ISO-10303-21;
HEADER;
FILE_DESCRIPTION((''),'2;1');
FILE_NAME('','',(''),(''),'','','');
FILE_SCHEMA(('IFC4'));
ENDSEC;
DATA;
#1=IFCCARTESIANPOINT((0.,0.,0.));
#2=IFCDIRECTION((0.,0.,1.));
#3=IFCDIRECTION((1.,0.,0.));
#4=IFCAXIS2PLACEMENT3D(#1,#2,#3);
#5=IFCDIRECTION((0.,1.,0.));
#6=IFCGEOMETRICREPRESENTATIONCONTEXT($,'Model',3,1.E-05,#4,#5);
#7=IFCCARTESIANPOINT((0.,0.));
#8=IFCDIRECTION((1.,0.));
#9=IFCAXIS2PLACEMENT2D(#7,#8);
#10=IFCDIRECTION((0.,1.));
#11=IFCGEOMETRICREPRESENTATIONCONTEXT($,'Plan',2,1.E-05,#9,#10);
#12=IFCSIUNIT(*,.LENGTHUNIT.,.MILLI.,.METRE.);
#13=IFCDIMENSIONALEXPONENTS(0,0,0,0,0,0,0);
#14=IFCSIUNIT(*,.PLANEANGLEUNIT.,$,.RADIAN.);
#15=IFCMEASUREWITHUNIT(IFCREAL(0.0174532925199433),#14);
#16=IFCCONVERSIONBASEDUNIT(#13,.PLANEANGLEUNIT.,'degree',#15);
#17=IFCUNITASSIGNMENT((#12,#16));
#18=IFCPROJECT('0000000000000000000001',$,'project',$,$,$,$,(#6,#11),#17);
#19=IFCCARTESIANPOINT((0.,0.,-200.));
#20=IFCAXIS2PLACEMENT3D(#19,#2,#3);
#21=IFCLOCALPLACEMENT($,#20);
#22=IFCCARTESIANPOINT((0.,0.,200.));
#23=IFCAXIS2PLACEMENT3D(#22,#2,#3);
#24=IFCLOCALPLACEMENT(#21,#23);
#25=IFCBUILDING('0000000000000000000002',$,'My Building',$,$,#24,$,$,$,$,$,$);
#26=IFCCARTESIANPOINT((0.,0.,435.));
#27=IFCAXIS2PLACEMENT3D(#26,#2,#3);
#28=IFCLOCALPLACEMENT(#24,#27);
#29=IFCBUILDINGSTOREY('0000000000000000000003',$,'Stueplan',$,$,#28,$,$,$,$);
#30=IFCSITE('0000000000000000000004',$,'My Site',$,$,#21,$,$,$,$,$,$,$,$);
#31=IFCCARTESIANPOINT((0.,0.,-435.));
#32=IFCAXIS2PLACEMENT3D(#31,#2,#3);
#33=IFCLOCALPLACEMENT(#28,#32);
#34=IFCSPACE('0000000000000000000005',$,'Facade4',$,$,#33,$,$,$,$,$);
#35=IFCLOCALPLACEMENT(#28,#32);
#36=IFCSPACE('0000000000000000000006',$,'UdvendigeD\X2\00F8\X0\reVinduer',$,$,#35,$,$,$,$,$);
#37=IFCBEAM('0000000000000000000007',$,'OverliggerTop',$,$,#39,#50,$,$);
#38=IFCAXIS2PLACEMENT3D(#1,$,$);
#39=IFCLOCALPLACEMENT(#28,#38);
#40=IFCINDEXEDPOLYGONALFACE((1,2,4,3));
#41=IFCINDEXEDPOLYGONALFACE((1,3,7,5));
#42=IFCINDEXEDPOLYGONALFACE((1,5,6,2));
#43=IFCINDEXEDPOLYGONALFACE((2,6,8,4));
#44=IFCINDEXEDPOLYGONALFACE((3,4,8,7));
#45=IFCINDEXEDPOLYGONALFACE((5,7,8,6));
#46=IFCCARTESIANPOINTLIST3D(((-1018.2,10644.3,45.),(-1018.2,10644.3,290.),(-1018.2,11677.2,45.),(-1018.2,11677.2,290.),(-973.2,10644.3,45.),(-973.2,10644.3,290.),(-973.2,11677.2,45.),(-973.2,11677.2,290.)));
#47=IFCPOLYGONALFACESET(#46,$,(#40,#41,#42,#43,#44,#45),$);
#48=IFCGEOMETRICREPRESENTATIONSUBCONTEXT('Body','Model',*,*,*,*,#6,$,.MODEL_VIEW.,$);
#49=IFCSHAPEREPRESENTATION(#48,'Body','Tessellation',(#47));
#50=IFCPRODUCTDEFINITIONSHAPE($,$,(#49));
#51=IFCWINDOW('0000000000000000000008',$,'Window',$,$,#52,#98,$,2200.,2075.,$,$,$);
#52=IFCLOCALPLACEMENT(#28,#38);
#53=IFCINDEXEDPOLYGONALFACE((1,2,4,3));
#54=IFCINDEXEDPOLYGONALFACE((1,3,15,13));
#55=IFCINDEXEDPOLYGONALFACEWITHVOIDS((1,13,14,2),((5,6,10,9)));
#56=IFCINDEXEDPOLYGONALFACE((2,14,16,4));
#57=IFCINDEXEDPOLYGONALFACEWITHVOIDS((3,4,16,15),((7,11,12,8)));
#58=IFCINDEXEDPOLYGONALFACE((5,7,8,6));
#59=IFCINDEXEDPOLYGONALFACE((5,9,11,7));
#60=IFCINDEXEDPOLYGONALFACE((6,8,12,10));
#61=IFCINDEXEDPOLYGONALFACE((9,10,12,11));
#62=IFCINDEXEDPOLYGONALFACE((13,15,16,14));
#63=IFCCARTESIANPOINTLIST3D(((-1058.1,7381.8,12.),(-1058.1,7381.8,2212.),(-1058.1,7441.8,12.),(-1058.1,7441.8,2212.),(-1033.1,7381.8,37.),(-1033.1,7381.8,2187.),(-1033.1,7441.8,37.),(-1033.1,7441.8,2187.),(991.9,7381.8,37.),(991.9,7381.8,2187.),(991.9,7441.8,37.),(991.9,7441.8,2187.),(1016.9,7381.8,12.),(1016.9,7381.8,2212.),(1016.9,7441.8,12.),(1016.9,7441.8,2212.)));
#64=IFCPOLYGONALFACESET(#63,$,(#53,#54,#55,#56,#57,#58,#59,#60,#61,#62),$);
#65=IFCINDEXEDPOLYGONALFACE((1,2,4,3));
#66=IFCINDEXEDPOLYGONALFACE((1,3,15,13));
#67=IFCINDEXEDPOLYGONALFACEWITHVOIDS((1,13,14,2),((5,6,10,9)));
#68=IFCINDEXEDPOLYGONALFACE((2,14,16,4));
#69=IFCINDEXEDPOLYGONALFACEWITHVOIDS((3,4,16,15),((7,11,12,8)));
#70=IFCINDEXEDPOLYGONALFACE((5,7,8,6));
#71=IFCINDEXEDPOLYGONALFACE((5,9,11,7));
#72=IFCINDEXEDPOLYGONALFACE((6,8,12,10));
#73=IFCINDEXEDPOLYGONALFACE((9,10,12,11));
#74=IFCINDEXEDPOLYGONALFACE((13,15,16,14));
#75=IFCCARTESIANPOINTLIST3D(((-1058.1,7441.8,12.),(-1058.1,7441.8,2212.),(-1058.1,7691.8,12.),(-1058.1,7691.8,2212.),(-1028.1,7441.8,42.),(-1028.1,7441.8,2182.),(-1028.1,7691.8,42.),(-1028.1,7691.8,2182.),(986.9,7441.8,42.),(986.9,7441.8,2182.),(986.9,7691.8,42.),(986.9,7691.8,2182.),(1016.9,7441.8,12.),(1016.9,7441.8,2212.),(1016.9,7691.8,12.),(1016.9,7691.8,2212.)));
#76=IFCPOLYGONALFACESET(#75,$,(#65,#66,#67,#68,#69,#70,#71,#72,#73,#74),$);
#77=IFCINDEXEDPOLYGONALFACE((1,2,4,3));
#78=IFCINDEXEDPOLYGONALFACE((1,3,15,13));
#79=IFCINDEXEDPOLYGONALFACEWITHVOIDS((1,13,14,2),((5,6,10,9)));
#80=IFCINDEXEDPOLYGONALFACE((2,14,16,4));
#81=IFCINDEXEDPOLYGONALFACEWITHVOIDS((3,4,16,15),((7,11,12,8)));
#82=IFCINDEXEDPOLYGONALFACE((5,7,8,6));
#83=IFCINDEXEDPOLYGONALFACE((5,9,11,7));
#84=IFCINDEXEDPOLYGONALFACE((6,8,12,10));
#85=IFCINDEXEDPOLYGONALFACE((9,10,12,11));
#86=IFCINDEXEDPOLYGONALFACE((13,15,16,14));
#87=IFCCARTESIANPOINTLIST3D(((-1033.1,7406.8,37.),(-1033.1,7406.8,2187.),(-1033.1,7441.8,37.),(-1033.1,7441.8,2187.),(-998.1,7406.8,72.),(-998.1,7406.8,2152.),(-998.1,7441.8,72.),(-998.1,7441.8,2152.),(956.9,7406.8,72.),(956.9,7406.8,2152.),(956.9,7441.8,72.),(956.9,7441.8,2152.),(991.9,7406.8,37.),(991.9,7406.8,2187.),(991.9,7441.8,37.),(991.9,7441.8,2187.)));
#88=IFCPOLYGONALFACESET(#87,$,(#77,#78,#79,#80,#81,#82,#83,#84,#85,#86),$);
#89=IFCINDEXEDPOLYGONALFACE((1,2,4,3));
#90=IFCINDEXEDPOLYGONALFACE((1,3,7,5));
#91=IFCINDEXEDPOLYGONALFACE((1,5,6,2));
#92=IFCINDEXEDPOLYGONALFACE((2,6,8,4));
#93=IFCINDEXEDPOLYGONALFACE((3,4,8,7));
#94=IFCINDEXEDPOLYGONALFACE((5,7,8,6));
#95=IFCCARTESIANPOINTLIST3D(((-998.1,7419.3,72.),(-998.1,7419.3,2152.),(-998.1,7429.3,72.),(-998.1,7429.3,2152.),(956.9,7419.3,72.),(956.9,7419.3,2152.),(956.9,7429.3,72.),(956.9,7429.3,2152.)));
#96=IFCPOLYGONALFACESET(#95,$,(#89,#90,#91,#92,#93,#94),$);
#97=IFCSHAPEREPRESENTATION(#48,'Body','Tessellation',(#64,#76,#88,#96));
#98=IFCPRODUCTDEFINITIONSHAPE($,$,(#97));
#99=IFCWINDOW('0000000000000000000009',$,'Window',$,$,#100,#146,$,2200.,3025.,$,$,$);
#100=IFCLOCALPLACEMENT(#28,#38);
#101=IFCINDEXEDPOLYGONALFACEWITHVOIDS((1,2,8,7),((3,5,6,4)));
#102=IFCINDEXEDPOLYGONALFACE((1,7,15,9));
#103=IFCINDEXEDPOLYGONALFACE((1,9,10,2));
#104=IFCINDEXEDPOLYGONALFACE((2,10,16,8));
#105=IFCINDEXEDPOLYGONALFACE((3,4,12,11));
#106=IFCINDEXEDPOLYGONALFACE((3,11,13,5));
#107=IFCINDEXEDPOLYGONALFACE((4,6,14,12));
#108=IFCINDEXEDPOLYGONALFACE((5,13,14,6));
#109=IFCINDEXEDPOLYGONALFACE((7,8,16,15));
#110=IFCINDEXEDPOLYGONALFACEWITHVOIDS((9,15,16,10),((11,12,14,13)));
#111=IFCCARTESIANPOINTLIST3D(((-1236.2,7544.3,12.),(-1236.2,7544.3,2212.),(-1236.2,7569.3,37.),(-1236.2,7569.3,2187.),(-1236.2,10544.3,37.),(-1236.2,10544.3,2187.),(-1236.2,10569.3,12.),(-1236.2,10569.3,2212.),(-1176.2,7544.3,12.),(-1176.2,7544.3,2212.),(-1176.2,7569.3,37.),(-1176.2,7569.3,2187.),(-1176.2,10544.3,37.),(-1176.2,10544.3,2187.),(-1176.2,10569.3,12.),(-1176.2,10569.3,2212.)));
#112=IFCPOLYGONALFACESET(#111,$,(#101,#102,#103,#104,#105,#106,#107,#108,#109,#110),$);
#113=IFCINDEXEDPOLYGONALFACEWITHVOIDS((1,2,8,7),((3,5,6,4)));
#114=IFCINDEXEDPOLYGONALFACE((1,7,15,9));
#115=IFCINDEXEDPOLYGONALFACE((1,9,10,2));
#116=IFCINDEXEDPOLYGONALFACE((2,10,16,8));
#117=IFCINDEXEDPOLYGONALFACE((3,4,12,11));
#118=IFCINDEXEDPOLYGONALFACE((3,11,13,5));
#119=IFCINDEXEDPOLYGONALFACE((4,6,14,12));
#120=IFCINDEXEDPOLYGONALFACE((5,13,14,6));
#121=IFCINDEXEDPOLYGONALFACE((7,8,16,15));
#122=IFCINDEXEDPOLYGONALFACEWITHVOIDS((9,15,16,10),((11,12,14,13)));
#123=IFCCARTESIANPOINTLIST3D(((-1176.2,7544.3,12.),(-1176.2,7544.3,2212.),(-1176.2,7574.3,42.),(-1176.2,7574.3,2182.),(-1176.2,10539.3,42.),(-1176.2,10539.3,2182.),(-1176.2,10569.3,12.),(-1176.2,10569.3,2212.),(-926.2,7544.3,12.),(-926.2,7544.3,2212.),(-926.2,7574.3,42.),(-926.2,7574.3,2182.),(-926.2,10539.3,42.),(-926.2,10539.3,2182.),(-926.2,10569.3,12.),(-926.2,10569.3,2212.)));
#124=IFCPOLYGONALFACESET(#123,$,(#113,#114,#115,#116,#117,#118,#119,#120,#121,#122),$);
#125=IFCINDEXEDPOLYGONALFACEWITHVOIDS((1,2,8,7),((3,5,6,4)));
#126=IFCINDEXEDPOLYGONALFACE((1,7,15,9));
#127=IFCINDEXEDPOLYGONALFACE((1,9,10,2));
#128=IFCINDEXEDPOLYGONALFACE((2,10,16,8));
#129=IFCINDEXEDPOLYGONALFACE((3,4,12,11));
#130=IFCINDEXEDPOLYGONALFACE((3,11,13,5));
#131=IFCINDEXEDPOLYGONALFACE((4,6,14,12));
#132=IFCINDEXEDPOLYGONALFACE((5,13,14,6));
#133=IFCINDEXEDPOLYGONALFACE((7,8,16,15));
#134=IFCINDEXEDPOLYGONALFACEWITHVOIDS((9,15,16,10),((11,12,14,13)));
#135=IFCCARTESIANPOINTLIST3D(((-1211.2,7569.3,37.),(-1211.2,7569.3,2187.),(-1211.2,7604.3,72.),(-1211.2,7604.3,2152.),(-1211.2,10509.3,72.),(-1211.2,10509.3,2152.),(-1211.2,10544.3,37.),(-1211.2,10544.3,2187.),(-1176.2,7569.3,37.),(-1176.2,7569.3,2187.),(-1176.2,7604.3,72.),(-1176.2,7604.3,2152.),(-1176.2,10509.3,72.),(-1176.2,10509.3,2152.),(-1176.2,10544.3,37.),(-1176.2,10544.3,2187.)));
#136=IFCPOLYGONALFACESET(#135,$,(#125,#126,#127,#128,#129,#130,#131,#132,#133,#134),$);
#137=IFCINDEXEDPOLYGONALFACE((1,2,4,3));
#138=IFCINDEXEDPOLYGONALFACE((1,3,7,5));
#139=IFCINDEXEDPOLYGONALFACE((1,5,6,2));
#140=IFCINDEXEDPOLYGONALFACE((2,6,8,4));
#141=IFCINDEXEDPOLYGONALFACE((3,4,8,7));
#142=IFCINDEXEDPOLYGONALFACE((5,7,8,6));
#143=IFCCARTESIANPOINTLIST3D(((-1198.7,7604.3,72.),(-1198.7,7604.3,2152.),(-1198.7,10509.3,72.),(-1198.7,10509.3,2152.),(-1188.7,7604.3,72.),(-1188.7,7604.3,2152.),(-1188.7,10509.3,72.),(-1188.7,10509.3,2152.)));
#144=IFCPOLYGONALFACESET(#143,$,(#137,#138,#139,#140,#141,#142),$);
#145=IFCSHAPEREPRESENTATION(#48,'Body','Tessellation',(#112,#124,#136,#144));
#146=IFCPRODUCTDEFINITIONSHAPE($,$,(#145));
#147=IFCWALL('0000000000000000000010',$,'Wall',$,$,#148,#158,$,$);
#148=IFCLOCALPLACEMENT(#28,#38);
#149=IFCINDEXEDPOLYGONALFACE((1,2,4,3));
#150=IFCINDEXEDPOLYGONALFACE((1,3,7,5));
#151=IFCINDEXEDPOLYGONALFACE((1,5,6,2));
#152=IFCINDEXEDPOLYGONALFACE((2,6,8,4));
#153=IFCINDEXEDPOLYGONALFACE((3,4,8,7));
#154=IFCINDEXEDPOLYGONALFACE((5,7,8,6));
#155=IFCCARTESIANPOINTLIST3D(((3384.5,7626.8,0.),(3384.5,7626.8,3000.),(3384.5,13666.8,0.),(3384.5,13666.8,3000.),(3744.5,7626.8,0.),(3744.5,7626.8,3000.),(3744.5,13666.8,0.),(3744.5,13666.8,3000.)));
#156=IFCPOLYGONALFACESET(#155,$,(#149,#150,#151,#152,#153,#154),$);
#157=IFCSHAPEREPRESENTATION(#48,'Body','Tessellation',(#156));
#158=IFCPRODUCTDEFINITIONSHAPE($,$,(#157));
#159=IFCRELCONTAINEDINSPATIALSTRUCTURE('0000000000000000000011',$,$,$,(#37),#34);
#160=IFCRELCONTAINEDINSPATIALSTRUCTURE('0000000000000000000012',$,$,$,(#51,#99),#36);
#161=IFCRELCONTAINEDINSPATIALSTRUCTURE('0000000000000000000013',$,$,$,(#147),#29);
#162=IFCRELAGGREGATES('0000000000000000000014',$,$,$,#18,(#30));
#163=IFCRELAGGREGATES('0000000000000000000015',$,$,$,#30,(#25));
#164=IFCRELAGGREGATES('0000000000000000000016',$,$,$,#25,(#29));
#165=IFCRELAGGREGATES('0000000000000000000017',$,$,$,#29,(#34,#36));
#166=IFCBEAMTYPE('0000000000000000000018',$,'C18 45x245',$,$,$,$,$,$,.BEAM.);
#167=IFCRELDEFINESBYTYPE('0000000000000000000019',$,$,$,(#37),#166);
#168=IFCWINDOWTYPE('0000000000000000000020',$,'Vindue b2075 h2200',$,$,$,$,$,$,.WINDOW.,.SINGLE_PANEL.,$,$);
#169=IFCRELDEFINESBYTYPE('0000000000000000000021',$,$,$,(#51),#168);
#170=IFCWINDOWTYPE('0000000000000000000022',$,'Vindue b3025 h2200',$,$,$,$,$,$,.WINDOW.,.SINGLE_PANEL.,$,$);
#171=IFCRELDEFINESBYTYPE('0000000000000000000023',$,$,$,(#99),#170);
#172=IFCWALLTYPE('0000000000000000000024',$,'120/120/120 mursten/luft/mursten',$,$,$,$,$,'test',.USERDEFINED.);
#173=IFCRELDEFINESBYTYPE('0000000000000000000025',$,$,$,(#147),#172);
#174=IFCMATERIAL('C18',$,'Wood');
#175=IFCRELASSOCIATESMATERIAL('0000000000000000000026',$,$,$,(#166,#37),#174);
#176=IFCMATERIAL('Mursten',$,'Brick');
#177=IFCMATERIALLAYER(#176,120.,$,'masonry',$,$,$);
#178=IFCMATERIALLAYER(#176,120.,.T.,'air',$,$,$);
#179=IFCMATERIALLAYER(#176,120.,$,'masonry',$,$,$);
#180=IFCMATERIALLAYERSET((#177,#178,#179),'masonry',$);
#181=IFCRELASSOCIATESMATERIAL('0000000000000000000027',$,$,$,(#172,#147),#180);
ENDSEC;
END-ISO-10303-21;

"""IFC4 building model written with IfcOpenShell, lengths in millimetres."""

from ifc_helpers import new_model, entity, si_unit, converted_unit, direction, frame, origin_with_axes, origin_2d_with_axis, place, context, subcontext, project, spatial, line, indexed_curve, rectangle, outline, extrude, shape, source, transform, mapped, material, layer, layer_set, layer_usage, material_profile, profile_set, profile_usage, type_object, type_shapes, element, save


model = new_model("IFC4")

# Units and contexts
model_context = context("Model", 3, precision=1e-05, world=origin_with_axes(), true_north=direction((0.0, 1.0, 0.0)))
plan_context = context("Plan", 2, precision=1e-05, world=origin_2d_with_axis(), true_north=direction((0.0, 1.0)))
body_context_1 = subcontext(model_context, "Body", "Model", "MODEL_VIEW")
body_context_2 = subcontext(plan_context, "Body", "Plan", "PLAN_VIEW")
ifc_project = project(units=[si_unit("LENGTHUNIT", "METRE", prefix="MILLI"), converted_unit("PLANEANGLEUNIT", "degree", entity("IfcReal", 0.0174532925199433), si_unit("PLANEANGLEUNIT", "RADIAN"), dimensions=[0, 0, 0, 0, 0, 0, 0])], contexts=[model_context, plan_context])

# Site, building, storey
site_placement = place(None, frame((0.0, 0.0, -200.0), z_axis=(0.0, 0.0, 1.0), x_axis=(1.0, 0.0, 0.0)))
site = spatial("IfcSite", under=ifc_project, at=site_placement, Name="My Site")
building_placement = place(site_placement, frame((0.0, 0.0, 200.0), z_axis=(0.0, 0.0, 1.0), x_axis=(1.0, 0.0, 0.0)))
building = spatial("IfcBuilding", under=site, at=building_placement, Name="My Building")
storey_placement = place(building_placement, frame((0.0, 0.0, 435.0), z_axis=(0.0, 0.0, 1.0), x_axis=(1.0, 0.0, 0.0)))
storey = spatial("IfcBuildingStorey", under=building, at=storey_placement, Name="Stueplan")

# Shared definitions
ifc_material_1 = material(Name="C18", Category="Wood")

# Shared definitions
space_1_placement = place(storey_placement, frame((0.0, 0.0, -435.0), z_axis=(0.0, 0.0, 1.0), x_axis=(1.0, 0.0, 0.0)))
space_1 = spatial("IfcSpace", under=storey, at=space_1_placement, Name="Facade4")

# Beam
ifc_material_profile_1 = material_profile(ifc_material_1, rectangle(XDim=45.0, YDim=245.0), Name="concrete")
ifc_profile_set_1 = profile_set([ifc_material_profile_1], Name="woodStructural")
beam_type = type_object("IfcBeamType", Name="C18 45x245", PredefinedType="BEAM", material=ifc_profile_set_1)
ifc_profile_usage_1 = profile_usage(ifc_profile_set_1)
beam_1_placement = place(space_1_placement, frame((-995.7, 11677.2, 602.5), z_axis=(0.0, -1.0, 0.0), x_axis=(-1.0, 0.0, 0.0)))
element("IfcBeam", 1, at=beam_1_placement, inside=space_1, type_object=beam_type, material=ifc_profile_usage_1, Name="OverliggerTop", context=body_context_1, shape_type="SweptSolid", body=[
    extrude(rectangle(XDim=45.0, YDim=245.0), origin_with_axes(), (0.0, 0.0, 1.0), 1032.9),
])

# Shared definitions
space_2_placement = place(storey_placement, frame((0.0, 0.0, -435.0), z_axis=(0.0, 0.0, 1.0), x_axis=(1.0, 0.0, 0.0)))
space_2 = spatial("IfcSpace", under=storey, at=space_2_placement, Name="UdvendigeDøreVinduer")

# Windows
window_type_1 = type_object("IfcWindowType", Name="Vindue b2075 h2200", PartitioningType="SINGLE_PANEL", PredefinedType="WINDOW")
shared_shape_1 = source(origin_with_axes(), body_context_1, "Body", "SweptSolid", [
    extrude(outline(indexed_curve([(0.0, 0.0), (2075.0, 0.0), (2075.0, 2200.0), (0.0, 2200.0)], segments=[line(1, 2, 3, 4, 1)]), holes=[indexed_curve([(25.0, 25.0), (2050.0, 25.0), (2050.0, 2175.0), (25.0, 2175.0)], segments=[line(1, 2, 3, 4, 1)])]), frame((0.0, 250.0, 0.0), z_axis=(0.0, -1.0, 0.0), x_axis=(1.0, 0.0, 0.0)), (0.0, 0.0, -1.0), 60.0),
    extrude(outline(indexed_curve([(0.0, 0.0), (2075.0, 0.0), (2075.0, 2200.0), (0.0, 2200.0)], segments=[line(1, 2, 3, 4, 1)]), holes=[indexed_curve([(30.0, 30.0), (2045.0, 30.0), (2045.0, 2170.0), (30.0, 2170.0)], segments=[line(1, 2, 3, 4, 1)])]), frame((0.0, 0.0, 0.0), z_axis=(0.0, -1.0, 0.0), x_axis=(1.0, 0.0, 0.0)), (0.0, 0.0, -1.0), 250.0),
    extrude(outline(indexed_curve([(0.0, 0.0), (2025.0, 0.0), (2025.0, 2150.0), (0.0, 2150.0)], segments=[line(1, 2, 3, 4, 1)]), holes=[indexed_curve([(35.0, 35.0), (1990.0, 35.0), (1990.0, 2115.0), (35.0, 2115.0)], segments=[line(1, 2, 3, 4, 1)])]), frame((25.0, 250.0, 25.0), z_axis=(0.0, -1.0, 0.0), x_axis=(1.0, 0.0, 0.0)), (0.0, 0.0, -1.0), 35.0),
    extrude(outline(indexed_curve([(35.0, 35.0), (1990.0, 35.0), (1990.0, 2115.0), (35.0, 2115.0)], segments=[line(1, 2, 3, 4, 1)])), frame((25.0, 262.5, 25.0), z_axis=(0.0, -1.0, 0.0), x_axis=(1.0, 0.0, 0.0)), (0.0, 0.0, -1.0), 10.0),
])
shared_shape_2 = source(origin_with_axes(), body_context_2, "Body", "Curve2D", [
    entity("IfcIndexedPolyCurve", entity("IfcCartesianPointList2D", [[30.0, 0.0], [2045.0, 0.0]])),
    entity("IfcIndexedPolyCurve", entity("IfcCartesianPointList2D", [[0.0, 310.0], [25.0, 310.0], [25.0, 250.0], [30.0, 250.0], [30.0, 0.0], [0.0, 0.0]]), [entity("IfcLineIndex", [1, 2, 3, 4, 5, 6, 1])]),
    entity("IfcIndexedPolyCurve", entity("IfcCartesianPointList2D", [[2075.0, 310.0], [2050.0, 310.0], [2050.0, 250.0], [2045.0, 250.0], [2045.0, 0.0], [2075.0, 0.0]]), [entity("IfcLineIndex", [1, 2, 3, 4, 5, 6, 1])]),
    entity("IfcIndexedPolyCurve", entity("IfcCartesianPointList2D", [[25.0, 250.0], [60.0, 250.0], [60.0, 285.0], [25.0, 285.0]]), [entity("IfcLineIndex", [1, 2, 3, 4, 1])]),
    entity("IfcIndexedPolyCurve", entity("IfcCartesianPointList2D", [[2050.0, 250.0], [2015.0, 250.0], [2015.0, 285.0], [2050.0, 285.0]]), [entity("IfcLineIndex", [1, 2, 3, 4, 1])]),
    entity("IfcIndexedPolyCurve", entity("IfcCartesianPointList2D", [[60.0, 250.0], [2015.0, 250.0]])),
    entity("IfcIndexedPolyCurve", entity("IfcCartesianPointList2D", [[60.0, 285.0], [2015.0, 285.0]])),
    entity("IfcIndexedPolyCurve", entity("IfcCartesianPointList2D", [[60.0, 267.5], [2015.0, 267.5]])),
])
type_shapes(window_type_1, [shared_shape_1, shared_shape_2])
placement_1 = place(storey_placement, frame((0.0, 0.0, -435.0), z_axis=(0.0, 0.0, 1.0), x_axis=(1.0, 0.0, 0.0)))
placement_2 = place(placement_1, frame((10599.3, 7381.5, 447.0), z_axis=(0.0, 0.0, 1.0), x_axis=(-1.0, 0.0, 0.0)))
placement_3 = place(placement_2, frame((9582.4, -310.3, 0.0), z_axis=(0.0, 0.0, 1.0), x_axis=(1.0, 0.0, 0.0)))
window_1_placement = place(placement_3, frame((0.0, 0.0, 0.0), z_axis=(0.0, 0.0, 1.0), x_axis=(1.0, 0.0, 0.0)))
element("IfcWindow", 2, at=window_1_placement, inside=space_2, type_object=window_type_1, Name="Window", OverallHeight=2200.0, OverallWidth=2075.0, shapes=[
    shape(body_context_1, "Body", "MappedRepresentation", [mapped(shared_shape_1, transform((0.0, 0.0, 0.0), x_axis=(1.0, 0.0, 0.0), y_axis=(0.0, 1.0, 0.0), z_axis=(0.0, 0.0, 1.0), scale=1.0))]),
    shape(body_context_2, "Body", "MappedRepresentation", [mapped(shared_shape_2, transform((0.0, 0.0, 0.0), x_axis=(1.0, 0.0, 0.0), y_axis=(0.0, 1.0, 0.0), z_axis=(0.0, 0.0, 1.0), scale=1.0))]),
])
window_type_2 = type_object("IfcWindowType", Name="Vindue b3025 h2200", PartitioningType="SINGLE_PANEL", PredefinedType="WINDOW")
shared_shape_3 = source(origin_with_axes(), body_context_1, "Body", "SweptSolid", [
    extrude(outline(indexed_curve([(0.0, 0.0), (3025.0, 0.0), (3025.0, 2200.0), (0.0, 2200.0)], segments=[line(1, 2, 3, 4, 1)]), holes=[indexed_curve([(25.0, 25.0), (3000.0, 25.0), (3000.0, 2175.0), (25.0, 2175.0)], segments=[line(1, 2, 3, 4, 1)])]), frame((0.0, 250.0, 0.0), z_axis=(0.0, -1.0, 0.0), x_axis=(1.0, 0.0, 0.0)), (0.0, 0.0, -1.0), 60.0),
    extrude(outline(indexed_curve([(0.0, 0.0), (3025.0, 0.0), (3025.0, 2200.0), (0.0, 2200.0)], segments=[line(1, 2, 3, 4, 1)]), holes=[indexed_curve([(30.0, 30.0), (2995.0, 30.0), (2995.0, 2170.0), (30.0, 2170.0)], segments=[line(1, 2, 3, 4, 1)])]), frame((0.0, 0.0, 0.0), z_axis=(0.0, -1.0, 0.0), x_axis=(1.0, 0.0, 0.0)), (0.0, 0.0, -1.0), 250.0),
    extrude(outline(indexed_curve([(0.0, 0.0), (2975.0, 0.0), (2975.0, 2150.0), (0.0, 2150.0)], segments=[line(1, 2, 3, 4, 1)]), holes=[indexed_curve([(35.0, 35.0), (2940.0, 35.0), (2940.0, 2115.0), (35.0, 2115.0)], segments=[line(1, 2, 3, 4, 1)])]), frame((25.0, 250.0, 25.0), z_axis=(0.0, -1.0, 0.0), x_axis=(1.0, 0.0, 0.0)), (0.0, 0.0, -1.0), 35.0),
    extrude(outline(indexed_curve([(35.0, 35.0), (2940.0, 35.0), (2940.0, 2115.0), (35.0, 2115.0)], segments=[line(1, 2, 3, 4, 1)])), frame((25.0, 262.5, 25.0), z_axis=(0.0, -1.0, 0.0), x_axis=(1.0, 0.0, 0.0)), (0.0, 0.0, -1.0), 10.0),
])
shared_shape_4 = source(origin_with_axes(), body_context_2, "Body", "Curve2D", [
    entity("IfcIndexedPolyCurve", entity("IfcCartesianPointList2D", [[30.0, 0.0], [2995.0, 0.0]])),
    entity("IfcIndexedPolyCurve", entity("IfcCartesianPointList2D", [[0.0, 310.0], [25.0, 310.0], [25.0, 250.0], [30.0, 250.0], [30.0, 0.0], [0.0, 0.0]]), [entity("IfcLineIndex", [1, 2, 3, 4, 5, 6, 1])]),
    entity("IfcIndexedPolyCurve", entity("IfcCartesianPointList2D", [[3025.0, 310.0], [3000.0, 310.0], [3000.0, 250.0], [2995.0, 250.0], [2995.0, 0.0], [3025.0, 0.0]]), [entity("IfcLineIndex", [1, 2, 3, 4, 5, 6, 1])]),
    entity("IfcIndexedPolyCurve", entity("IfcCartesianPointList2D", [[25.0, 250.0], [60.0, 250.0], [60.0, 285.0], [25.0, 285.0]]), [entity("IfcLineIndex", [1, 2, 3, 4, 1])]),
    entity("IfcIndexedPolyCurve", entity("IfcCartesianPointList2D", [[3000.0, 250.0], [2965.0, 250.0], [2965.0, 285.0], [3000.0, 285.0]]), [entity("IfcLineIndex", [1, 2, 3, 4, 1])]),
    entity("IfcIndexedPolyCurve", entity("IfcCartesianPointList2D", [[60.0, 250.0], [2965.0, 250.0]])),
    entity("IfcIndexedPolyCurve", entity("IfcCartesianPointList2D", [[60.0, 285.0], [2965.0, 285.0]])),
    entity("IfcIndexedPolyCurve", entity("IfcCartesianPointList2D", [[60.0, 267.5], [2965.0, 267.5]])),
])
type_shapes(window_type_2, [shared_shape_3, shared_shape_4])
placement_4 = place(placement_1, frame((-1218.2, 7381.5, 435.0), z_axis=(0.0, 0.0, 1.0), x_axis=(0.000001, 1.0, 0.0)))
placement_5 = place(placement_4, frame((162.8, -292.0, 12.0), z_axis=(0.0, 0.0, 1.0), x_axis=(1.0, 0.0, 0.0)))
window_2_placement = place(placement_5, frame((0.0, 0.0, 0.0), z_axis=(0.0, 0.0, 1.0), x_axis=(1.0, 0.0, 0.0)))
element("IfcWindow", 3, at=window_2_placement, inside=space_2, type_object=window_type_2, Name="Window", OverallHeight=2200.0, OverallWidth=3025.0, shapes=[
    shape(body_context_1, "Body", "MappedRepresentation", [mapped(shared_shape_3, transform((0.0, 0.0, 0.0), x_axis=(1.0, 0.0, 0.0), y_axis=(0.0, 1.0, 0.0), z_axis=(0.0, 0.0, 1.0), scale=1.0))]),
    shape(body_context_2, "Body", "MappedRepresentation", [mapped(shared_shape_4, transform((0.0, 0.0, 0.0), x_axis=(1.0, 0.0, 0.0), y_axis=(0.0, 1.0, 0.0), z_axis=(0.0, 0.0, 1.0), scale=1.0))]),
])

# Wall
ifc_material_2 = material(Name="Mursten", Category="Brick")
ifc_layer_1 = layer(ifc_material_2, 120.0, Name="masonry")
ifc_layer_2 = layer(ifc_material_2, 120.0, ventilated=True, Name="air")
ifc_layer_3 = layer(ifc_material_2, 120.0, Name="masonry")
ifc_layer_set = layer_set([ifc_layer_1, ifc_layer_2, ifc_layer_3], Name="masonry")
ifc_layer_usage = layer_usage(ifc_layer_set, "AXIS2", "POSITIVE", 0.0)
wall_type = type_object("IfcWallType", Name="120/120/120 mursten/luft/mursten", ElementType="test", PredefinedType="USERDEFINED", material=ifc_layer_set)
wall_placement = place(storey_placement, frame((3384.5, 13666.8, 0.0), z_axis=(0.0, 0.0, 1.0), x_axis=(-0.000001, -1.0, 0.0)))
element("IfcWall", 4, at=wall_placement, inside=storey, type_object=wall_type, material=ifc_layer_usage, Name="Wall", context=body_context_1, shape_type="SweptSolid", body=[
    extrude(outline(indexed_curve([(0.0, 0.0), (0.0, 360.0), (6040.0, 360.0), (6040.0, 0.0), (0.0, 0.0)], self_intersect=False)), origin_with_axes(), (0.0, 0.0, 1.0), 3000.0),
])

save(model, "model.ifc")
